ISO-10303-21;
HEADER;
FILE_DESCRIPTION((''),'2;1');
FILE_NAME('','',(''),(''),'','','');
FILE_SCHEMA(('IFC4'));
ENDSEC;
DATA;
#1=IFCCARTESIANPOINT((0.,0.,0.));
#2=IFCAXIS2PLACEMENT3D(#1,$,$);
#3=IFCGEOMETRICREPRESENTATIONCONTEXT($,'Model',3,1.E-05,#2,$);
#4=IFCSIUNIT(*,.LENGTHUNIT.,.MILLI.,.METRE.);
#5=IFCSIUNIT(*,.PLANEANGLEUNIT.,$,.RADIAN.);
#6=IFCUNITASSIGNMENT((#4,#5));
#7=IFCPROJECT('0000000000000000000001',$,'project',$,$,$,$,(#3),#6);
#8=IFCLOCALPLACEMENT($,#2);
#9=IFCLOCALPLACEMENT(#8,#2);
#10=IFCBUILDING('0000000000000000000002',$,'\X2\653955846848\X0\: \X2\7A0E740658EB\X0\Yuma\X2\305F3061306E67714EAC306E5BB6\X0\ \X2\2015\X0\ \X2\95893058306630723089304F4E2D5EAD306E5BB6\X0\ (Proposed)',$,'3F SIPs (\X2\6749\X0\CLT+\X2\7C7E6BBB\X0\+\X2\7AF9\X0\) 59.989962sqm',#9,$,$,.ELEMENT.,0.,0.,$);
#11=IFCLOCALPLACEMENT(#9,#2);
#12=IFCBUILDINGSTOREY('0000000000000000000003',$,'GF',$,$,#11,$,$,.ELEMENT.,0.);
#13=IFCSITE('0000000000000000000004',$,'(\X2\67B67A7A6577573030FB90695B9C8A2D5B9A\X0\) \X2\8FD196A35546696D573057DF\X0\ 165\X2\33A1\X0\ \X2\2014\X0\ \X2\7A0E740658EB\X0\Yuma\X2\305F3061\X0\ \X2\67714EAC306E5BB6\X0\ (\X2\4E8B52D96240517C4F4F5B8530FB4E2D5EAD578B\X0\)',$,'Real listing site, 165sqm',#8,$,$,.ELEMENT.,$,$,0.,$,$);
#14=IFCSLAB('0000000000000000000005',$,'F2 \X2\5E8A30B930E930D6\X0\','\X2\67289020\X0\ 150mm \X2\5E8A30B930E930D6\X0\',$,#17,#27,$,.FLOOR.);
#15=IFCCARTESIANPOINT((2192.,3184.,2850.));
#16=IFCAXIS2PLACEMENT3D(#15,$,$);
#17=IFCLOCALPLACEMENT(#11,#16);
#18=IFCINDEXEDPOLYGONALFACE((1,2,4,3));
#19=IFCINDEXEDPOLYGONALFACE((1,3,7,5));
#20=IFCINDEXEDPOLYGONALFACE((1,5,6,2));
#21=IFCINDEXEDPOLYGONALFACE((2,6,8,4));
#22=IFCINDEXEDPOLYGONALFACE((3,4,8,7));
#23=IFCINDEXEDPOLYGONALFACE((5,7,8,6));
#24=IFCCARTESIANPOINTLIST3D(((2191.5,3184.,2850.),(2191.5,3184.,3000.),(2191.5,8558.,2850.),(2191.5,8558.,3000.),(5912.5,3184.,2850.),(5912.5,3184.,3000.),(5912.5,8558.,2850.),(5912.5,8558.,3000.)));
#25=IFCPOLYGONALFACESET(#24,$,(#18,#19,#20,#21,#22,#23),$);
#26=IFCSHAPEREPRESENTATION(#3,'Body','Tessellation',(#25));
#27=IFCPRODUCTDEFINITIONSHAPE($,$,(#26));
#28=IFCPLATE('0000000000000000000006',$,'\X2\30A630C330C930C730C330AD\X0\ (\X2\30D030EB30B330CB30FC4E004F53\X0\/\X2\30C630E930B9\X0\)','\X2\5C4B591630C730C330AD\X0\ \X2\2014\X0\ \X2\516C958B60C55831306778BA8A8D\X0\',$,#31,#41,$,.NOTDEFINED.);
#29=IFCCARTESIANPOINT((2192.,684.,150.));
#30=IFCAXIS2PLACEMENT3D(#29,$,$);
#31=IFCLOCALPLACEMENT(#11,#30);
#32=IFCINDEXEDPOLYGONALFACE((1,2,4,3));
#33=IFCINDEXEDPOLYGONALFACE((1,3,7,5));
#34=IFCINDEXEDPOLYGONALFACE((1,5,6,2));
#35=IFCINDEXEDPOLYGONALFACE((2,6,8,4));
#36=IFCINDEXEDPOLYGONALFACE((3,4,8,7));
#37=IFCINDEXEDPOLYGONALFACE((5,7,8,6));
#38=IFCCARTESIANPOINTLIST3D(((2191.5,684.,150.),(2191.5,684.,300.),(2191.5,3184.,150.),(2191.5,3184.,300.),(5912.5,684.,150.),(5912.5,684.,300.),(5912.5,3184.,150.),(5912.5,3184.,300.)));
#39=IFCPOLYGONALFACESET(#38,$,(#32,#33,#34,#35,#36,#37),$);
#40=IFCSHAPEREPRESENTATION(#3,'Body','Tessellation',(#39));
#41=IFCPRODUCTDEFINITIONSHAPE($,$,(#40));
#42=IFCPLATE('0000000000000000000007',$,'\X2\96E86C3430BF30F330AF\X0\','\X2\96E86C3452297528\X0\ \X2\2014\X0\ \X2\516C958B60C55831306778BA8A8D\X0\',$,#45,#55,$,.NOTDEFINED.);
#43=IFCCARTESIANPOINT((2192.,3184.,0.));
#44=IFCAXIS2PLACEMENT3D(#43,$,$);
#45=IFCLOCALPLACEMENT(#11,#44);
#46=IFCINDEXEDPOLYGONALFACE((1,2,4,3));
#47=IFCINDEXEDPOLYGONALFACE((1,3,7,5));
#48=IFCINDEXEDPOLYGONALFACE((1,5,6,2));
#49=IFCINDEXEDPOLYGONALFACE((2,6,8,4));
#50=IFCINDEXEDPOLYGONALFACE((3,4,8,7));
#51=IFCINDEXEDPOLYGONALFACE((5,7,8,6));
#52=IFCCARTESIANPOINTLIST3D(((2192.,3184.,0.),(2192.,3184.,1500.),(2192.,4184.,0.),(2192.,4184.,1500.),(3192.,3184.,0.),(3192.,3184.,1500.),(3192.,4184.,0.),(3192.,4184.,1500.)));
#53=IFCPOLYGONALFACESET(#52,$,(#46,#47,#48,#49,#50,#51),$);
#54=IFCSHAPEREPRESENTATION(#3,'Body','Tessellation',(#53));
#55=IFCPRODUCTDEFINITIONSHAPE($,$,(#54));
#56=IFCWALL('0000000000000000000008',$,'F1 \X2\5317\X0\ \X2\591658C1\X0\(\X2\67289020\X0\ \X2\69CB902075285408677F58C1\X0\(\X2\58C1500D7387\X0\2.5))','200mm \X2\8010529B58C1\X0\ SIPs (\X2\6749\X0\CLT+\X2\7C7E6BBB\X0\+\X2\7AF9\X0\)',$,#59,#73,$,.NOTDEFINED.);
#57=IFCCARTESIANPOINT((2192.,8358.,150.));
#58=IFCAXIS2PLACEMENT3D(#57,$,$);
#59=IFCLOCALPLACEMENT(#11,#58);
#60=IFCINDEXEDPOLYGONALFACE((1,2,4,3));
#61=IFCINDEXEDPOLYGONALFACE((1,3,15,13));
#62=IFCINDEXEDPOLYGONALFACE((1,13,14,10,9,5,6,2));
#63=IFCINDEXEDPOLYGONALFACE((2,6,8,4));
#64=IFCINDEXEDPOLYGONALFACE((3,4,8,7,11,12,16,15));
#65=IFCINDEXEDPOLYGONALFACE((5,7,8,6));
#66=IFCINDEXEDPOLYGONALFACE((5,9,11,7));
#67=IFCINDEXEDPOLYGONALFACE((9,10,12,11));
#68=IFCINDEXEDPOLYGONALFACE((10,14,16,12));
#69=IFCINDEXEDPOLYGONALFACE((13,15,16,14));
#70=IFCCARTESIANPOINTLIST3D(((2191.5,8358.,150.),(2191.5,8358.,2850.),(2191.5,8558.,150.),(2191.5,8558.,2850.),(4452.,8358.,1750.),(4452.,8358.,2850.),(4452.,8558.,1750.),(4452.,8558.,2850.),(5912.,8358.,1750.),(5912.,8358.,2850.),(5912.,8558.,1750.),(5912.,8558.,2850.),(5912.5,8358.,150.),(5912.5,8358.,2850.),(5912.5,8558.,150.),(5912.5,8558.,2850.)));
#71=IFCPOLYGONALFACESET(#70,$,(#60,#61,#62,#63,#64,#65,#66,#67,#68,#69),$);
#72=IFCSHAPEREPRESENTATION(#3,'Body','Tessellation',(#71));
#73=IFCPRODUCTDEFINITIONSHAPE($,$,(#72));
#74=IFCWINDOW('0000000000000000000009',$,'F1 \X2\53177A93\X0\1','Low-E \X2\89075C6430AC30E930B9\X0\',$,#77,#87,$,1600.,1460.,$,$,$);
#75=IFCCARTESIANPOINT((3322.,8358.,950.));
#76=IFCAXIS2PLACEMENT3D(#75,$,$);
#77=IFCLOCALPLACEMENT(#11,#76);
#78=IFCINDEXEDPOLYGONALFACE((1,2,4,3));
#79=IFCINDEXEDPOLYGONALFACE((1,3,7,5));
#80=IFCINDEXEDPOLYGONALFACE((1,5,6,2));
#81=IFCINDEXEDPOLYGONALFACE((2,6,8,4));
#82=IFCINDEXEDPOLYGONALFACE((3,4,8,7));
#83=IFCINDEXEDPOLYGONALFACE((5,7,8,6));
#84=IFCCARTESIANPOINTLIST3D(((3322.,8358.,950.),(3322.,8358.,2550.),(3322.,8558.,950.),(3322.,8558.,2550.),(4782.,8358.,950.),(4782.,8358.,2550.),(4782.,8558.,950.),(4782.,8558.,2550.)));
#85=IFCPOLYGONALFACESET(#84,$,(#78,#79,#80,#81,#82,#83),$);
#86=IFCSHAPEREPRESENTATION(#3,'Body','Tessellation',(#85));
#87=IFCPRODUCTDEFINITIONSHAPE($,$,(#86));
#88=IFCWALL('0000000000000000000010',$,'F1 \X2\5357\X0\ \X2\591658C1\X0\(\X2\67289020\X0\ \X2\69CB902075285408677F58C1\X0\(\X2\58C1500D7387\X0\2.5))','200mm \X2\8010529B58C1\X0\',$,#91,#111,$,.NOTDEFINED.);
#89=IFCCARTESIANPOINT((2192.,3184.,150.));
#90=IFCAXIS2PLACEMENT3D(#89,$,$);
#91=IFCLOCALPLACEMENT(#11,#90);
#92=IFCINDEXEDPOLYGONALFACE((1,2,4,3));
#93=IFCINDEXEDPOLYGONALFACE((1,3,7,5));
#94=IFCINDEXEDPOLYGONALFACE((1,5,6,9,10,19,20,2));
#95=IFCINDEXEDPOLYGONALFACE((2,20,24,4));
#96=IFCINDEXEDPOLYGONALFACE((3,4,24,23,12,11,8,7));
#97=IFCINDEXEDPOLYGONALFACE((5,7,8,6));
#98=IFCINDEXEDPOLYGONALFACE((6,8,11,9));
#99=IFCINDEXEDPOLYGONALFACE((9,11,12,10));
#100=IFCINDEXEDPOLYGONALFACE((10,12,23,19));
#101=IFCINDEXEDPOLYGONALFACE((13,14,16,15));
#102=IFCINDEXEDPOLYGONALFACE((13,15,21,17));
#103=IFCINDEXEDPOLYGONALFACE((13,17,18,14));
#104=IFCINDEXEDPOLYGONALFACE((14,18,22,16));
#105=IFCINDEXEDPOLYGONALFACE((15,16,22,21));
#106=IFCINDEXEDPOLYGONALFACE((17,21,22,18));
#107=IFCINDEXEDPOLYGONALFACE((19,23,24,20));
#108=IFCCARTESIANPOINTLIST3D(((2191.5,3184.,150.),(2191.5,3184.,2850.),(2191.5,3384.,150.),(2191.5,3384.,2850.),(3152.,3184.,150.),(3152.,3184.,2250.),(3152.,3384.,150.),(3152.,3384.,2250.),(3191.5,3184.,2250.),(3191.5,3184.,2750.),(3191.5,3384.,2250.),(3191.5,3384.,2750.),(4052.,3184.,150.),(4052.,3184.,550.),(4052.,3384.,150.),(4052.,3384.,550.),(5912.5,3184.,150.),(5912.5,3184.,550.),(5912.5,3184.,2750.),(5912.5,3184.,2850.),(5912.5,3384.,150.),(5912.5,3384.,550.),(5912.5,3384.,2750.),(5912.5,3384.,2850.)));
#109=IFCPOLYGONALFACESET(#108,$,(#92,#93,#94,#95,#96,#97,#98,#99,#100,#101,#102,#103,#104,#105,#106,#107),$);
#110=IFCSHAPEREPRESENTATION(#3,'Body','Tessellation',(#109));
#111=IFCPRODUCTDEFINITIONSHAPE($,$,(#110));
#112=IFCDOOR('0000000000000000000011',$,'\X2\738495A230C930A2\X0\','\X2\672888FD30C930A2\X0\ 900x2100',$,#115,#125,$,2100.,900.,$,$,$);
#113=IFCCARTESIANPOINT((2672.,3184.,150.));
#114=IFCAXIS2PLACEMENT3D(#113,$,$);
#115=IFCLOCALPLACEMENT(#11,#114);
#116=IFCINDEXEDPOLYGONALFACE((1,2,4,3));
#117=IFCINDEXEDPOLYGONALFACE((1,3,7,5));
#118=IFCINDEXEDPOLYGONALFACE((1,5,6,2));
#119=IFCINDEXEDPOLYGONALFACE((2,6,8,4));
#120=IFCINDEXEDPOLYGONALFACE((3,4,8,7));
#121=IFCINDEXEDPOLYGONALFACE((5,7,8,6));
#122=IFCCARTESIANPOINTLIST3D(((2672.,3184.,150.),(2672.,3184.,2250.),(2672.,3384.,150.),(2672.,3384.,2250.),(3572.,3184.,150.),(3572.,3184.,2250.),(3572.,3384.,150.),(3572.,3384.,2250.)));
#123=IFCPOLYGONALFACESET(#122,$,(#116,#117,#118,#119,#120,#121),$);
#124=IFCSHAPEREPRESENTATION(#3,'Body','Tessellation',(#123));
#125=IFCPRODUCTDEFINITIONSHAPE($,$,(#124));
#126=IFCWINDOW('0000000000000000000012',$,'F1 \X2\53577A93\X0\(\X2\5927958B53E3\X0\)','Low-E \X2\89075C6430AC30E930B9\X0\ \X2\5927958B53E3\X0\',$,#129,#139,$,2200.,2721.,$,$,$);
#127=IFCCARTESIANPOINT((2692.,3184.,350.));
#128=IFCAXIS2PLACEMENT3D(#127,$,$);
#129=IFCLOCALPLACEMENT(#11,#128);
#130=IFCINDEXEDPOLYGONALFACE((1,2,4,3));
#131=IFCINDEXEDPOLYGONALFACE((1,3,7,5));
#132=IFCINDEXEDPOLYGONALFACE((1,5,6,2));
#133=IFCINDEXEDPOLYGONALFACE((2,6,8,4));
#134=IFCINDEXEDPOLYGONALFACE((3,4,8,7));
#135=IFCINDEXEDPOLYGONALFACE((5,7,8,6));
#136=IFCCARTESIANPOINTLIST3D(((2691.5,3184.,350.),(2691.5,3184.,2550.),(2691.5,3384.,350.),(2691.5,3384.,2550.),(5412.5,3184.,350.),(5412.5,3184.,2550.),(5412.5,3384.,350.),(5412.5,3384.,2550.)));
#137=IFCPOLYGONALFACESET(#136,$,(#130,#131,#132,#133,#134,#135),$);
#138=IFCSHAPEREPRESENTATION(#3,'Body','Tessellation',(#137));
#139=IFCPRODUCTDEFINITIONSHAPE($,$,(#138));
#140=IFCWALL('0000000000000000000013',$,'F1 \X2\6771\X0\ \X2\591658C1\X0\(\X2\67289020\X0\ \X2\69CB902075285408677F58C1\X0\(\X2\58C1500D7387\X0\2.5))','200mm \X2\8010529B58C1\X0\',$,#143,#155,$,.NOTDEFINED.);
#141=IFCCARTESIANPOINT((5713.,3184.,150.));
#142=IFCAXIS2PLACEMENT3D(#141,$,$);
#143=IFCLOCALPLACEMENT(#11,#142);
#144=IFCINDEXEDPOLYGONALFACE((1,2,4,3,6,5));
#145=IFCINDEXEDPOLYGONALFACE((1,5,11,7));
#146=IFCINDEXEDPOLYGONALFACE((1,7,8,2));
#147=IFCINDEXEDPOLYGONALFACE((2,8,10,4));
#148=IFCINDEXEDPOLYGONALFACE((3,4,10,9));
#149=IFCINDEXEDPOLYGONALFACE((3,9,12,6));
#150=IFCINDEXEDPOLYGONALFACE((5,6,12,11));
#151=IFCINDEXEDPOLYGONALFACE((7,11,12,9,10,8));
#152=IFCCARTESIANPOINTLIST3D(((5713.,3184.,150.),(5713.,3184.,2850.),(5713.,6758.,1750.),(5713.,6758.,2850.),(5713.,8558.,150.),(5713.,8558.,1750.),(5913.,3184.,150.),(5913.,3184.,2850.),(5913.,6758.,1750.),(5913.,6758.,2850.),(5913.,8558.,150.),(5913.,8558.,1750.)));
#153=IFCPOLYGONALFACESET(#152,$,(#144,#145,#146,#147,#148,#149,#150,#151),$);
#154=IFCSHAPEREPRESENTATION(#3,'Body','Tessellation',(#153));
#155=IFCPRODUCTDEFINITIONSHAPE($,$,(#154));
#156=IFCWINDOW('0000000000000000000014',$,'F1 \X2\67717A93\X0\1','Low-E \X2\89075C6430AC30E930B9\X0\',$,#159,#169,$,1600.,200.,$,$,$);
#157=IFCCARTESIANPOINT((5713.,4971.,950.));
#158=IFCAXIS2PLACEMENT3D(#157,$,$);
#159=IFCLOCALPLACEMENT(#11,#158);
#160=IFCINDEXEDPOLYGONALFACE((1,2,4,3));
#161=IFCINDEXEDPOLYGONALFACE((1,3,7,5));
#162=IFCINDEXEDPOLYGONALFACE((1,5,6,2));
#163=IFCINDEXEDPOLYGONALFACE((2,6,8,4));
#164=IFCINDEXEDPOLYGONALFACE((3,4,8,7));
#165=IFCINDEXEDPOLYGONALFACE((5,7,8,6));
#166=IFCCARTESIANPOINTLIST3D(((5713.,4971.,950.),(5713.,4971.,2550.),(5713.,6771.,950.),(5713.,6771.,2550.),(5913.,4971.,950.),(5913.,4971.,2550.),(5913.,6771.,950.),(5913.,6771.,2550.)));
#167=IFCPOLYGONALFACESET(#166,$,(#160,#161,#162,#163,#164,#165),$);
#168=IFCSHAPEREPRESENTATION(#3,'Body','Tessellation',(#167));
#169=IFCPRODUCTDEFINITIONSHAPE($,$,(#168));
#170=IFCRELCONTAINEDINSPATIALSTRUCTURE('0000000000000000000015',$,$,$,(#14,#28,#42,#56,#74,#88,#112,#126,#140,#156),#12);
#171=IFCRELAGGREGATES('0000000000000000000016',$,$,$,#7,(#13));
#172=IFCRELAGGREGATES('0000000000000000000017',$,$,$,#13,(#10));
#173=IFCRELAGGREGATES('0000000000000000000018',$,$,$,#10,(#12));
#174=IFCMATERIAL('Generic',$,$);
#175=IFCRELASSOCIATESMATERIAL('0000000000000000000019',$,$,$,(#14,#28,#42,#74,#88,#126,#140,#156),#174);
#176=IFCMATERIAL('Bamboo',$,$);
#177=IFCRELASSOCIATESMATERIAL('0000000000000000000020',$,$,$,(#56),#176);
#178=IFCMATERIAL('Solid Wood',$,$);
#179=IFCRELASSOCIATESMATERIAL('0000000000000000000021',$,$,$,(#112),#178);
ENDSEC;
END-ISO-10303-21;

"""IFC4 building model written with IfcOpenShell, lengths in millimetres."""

from ifc_helpers import new_model, si_unit, frame, frame_2d, origin, place, context, project, spatial, rectangle, extrude, material, element, fill, save


model = new_model("IFC4")

# Units and contexts
model_context = context("Model", 3, precision=1e-05, world=origin())
ifc_project = project(units=[si_unit("LENGTHUNIT", "METRE", prefix="MILLI"), si_unit("PLANEANGLEUNIT", "RADIAN")], contexts=[model_context])

# Site, building, storey
site_placement = place(None, origin())
site = spatial("IfcSite", under=ifc_project, at=site_placement, Name="(架空敷地・適宜設定) 近隣商業地域 165㎡ — 税理士Yumaたち 東京の家 (事務所兼住宅・中庭型)", ObjectType="Real listing site, 165sqm", CompositionType="ELEMENT", RefElevation=0.0)
building_placement = place(site_placement, origin())
building = spatial("IfcBuilding", under=site, at=building_placement, Name="改善案: 税理士Yumaたちの東京の家 ― 閉じてひらく中庭の家 (Proposed)", ObjectType="3F SIPs (杉CLT+籾殻+竹) 59.989962sqm", CompositionType="ELEMENT", ElevationOfRefHeight=0.0, ElevationOfTerrain=0.0)
storey_placement = place(building_placement, origin())
storey = spatial("IfcBuildingStorey", under=building, at=storey_placement, Name="GF", CompositionType="ELEMENT", Elevation=0.0)

# Slab
ifc_material_1 = material(Name="Generic")
slab_1_placement = place(storey_placement, frame((2192.0, 3184.0, 2850.0)))
element("IfcSlab", 1, at=slab_1_placement, inside=storey, material=ifc_material_1, Name="F2 床スラブ", Description="木造 150mm 床スラブ", PredefinedType="FLOOR", context=model_context, shape_type="SweptSolid", body=[
    extrude(rectangle(XDim=3721.0, YDim=5374.0, at=frame_2d((1860.0, 2687.0))), frame((2192.0, 3184.0, 2850.0)), (0.0, 0.0, 1.0), 150.0),
])

# Plates
plate_1_placement = place(storey_placement, frame((2192.0, 684.0, 150.0)))
element("IfcPlate", 2, at=plate_1_placement, inside=storey, material=ifc_material_1, Name="ウッドデッキ (バルコニー一体/テラス)", Description="屋外デッキ — 公開情報で確認", PredefinedType="NOTDEFINED", context=model_context, shape_type="SweptSolid", body=[
    extrude(rectangle(XDim=3721.0, YDim=2500.0, at=frame_2d((1860.0, 1250.0))), frame((2192.0, 684.0, 150.0)), (0.0, 0.0, 1.0), 150.0),
])
plate_2_placement = place(storey_placement, frame((2192.0, 3184.0, 0.0)))
element("IfcPlate", 3, at=plate_2_placement, inside=storey, material=ifc_material_1, Name="雨水タンク", Description="雨水利用 — 公開情報で確認", PredefinedType="NOTDEFINED", context=model_context, shape_type="SweptSolid", body=[
    extrude(rectangle(XDim=1000.0, YDim=1000.0, at=frame_2d((500.0, 500.0))), frame((2192.0, 3184.0, 0.0)), (0.0, 0.0, 1.0), 1500.0),
])

# Wall, opening, window
ifc_material_2 = material(Name="Bamboo")
wall_1_placement = place(storey_placement, frame((2192.0, 8358.0, 150.0)))
wall_1 = element("IfcWall", 4, at=wall_1_placement, inside=storey, material=ifc_material_2, Name="F1 北 外壁(木造 構造用合板壁(壁倍率2.5))", Description="200mm 耐力壁 SIPs (杉CLT+籾殻+竹)", PredefinedType="NOTDEFINED", context=model_context, shape_type="SweptSolid", body=[
    extrude(rectangle(XDim=3721.0, YDim=200.0, at=frame_2d((1860.0, 100.0))), frame((2192.0, 8358.0, 150.0)), (0.0, 0.0, 1.0), 2700.0),
])
opening_1_placement = place(storey_placement, frame((3322.0, 8358.0, 950.0)))
opening_1 = element("IfcOpeningElement", 5, at=opening_1_placement, cuts=wall_1, PredefinedType="NOTDEFINED", context=model_context, shape_type="SweptSolid", body=[
    extrude(rectangle(XDim=1460.0, YDim=200.0, at=frame_2d((730.0, 100.0))), frame((3322.0, 8358.0, 950.0)), (0.0, 0.0, 1.0), 1600.0),
])
window_1_placement = place(storey_placement, frame((3322.0, 8358.0, 950.0)))
window_1 = element("IfcWindow", 6, at=window_1_placement, inside=storey, material=ifc_material_1, Name="F1 北窓1", Description="Low-E 複層ガラス", OverallHeight=1600.0, OverallWidth=1460.0, context=model_context, shape_type="SweptSolid", body=[
    extrude(rectangle(XDim=1460.0, YDim=200.0, at=frame_2d((730.0, 100.0))), frame((3322.0, 8358.0, 950.0)), (0.0, 0.0, 1.0), 1600.0),
])
fill(opening_1, window_1)

# Wall, openings, door, window
wall_2_placement = place(storey_placement, frame((2192.0, 3184.0, 150.0)))
wall_2 = element("IfcWall", 7, at=wall_2_placement, inside=storey, material=ifc_material_1, Name="F1 南 外壁(木造 構造用合板壁(壁倍率2.5))", Description="200mm 耐力壁", PredefinedType="NOTDEFINED", context=model_context, shape_type="SweptSolid", body=[
    extrude(rectangle(XDim=3721.0, YDim=200.0, at=frame_2d((1860.0, 100.0))), frame((2192.0, 3184.0, 150.0)), (0.0, 0.0, 1.0), 2700.0),
])
opening_2_placement = place(storey_placement, frame((2672.0, 3184.0, 150.0)))
opening_2 = element("IfcOpeningElement", 8, at=opening_2_placement, cuts=wall_2, PredefinedType="NOTDEFINED", context=model_context, shape_type="SweptSolid", body=[
    extrude(rectangle(XDim=900.0, YDim=200.0, at=frame_2d((450.0, 100.0))), frame((2672.0, 3184.0, 150.0)), (0.0, 0.0, 1.0), 2100.0),
])
opening_3_placement = place(storey_placement, frame((2692.0, 3184.0, 350.0)))
opening_3 = element("IfcOpeningElement", 9, at=opening_3_placement, cuts=wall_2, PredefinedType="NOTDEFINED", context=model_context, shape_type="SweptSolid", body=[
    extrude(rectangle(XDim=2721.0, YDim=200.0, at=frame_2d((1360.0, 100.0))), frame((2692.0, 3184.0, 350.0)), (0.0, 0.0, 1.0), 2200.0),
])
ifc_material_3 = material(Name="Solid Wood")
door_placement = place(storey_placement, frame((2672.0, 3184.0, 150.0)))
door = element("IfcDoor", 10, at=door_placement, inside=storey, material=ifc_material_3, Name="玄関ドア", Description="木製ドア 900x2100", OverallHeight=2100.0, OverallWidth=900.0, context=model_context, shape_type="SweptSolid", body=[
    extrude(rectangle(XDim=900.0, YDim=200.0, at=frame_2d((450.0, 100.0))), frame((2672.0, 3184.0, 150.0)), (0.0, 0.0, 1.0), 2100.0),
])
fill(opening_2, door)
window_2_placement = place(storey_placement, frame((2692.0, 3184.0, 350.0)))
window_2 = element("IfcWindow", 11, at=window_2_placement, inside=storey, material=ifc_material_1, Name="F1 南窓(大開口)", Description="Low-E 複層ガラス 大開口", OverallHeight=2200.0, OverallWidth=2721.0, context=model_context, shape_type="SweptSolid", body=[
    extrude(rectangle(XDim=2721.0, YDim=200.0, at=frame_2d((1360.0, 100.0))), frame((2692.0, 3184.0, 350.0)), (0.0, 0.0, 1.0), 2200.0),
])
fill(opening_3, window_2)

# Wall, opening, window
wall_3_placement = place(storey_placement, frame((5713.0, 3184.0, 150.0)))
wall_3 = element("IfcWall", 12, at=wall_3_placement, inside=storey, material=ifc_material_1, Name="F1 東 外壁(木造 構造用合板壁(壁倍率2.5))", Description="200mm 耐力壁", PredefinedType="NOTDEFINED", context=model_context, shape_type="SweptSolid", body=[
    extrude(rectangle(XDim=200.0, YDim=5374.0, at=frame_2d((100.0, 2687.0))), frame((5713.0, 3184.0, 150.0)), (0.0, 0.0, 1.0), 2700.0),
])
opening_4_placement = place(storey_placement, frame((5713.0, 4971.0, 950.0)))
opening_4 = element("IfcOpeningElement", 13, at=opening_4_placement, cuts=wall_3, PredefinedType="NOTDEFINED", context=model_context, shape_type="SweptSolid", body=[
    extrude(rectangle(XDim=200.0, YDim=1800.0, at=frame_2d((100.0, 900.0))), frame((5713.0, 4971.0, 950.0)), (0.0, 0.0, 1.0), 1600.0),
])
window_3_placement = place(storey_placement, frame((5713.0, 4971.0, 950.0)))
window_3 = element("IfcWindow", 14, at=window_3_placement, inside=storey, material=ifc_material_1, Name="F1 東窓1", Description="Low-E 複層ガラス", OverallHeight=1600.0, OverallWidth=200.0, context=model_context, shape_type="SweptSolid", body=[
    extrude(rectangle(XDim=200.0, YDim=1800.0, at=frame_2d((100.0, 900.0))), frame((5713.0, 4971.0, 950.0)), (0.0, 0.0, 1.0), 1600.0),
])
fill(opening_4, window_3)

save(model, "model.ifc")
